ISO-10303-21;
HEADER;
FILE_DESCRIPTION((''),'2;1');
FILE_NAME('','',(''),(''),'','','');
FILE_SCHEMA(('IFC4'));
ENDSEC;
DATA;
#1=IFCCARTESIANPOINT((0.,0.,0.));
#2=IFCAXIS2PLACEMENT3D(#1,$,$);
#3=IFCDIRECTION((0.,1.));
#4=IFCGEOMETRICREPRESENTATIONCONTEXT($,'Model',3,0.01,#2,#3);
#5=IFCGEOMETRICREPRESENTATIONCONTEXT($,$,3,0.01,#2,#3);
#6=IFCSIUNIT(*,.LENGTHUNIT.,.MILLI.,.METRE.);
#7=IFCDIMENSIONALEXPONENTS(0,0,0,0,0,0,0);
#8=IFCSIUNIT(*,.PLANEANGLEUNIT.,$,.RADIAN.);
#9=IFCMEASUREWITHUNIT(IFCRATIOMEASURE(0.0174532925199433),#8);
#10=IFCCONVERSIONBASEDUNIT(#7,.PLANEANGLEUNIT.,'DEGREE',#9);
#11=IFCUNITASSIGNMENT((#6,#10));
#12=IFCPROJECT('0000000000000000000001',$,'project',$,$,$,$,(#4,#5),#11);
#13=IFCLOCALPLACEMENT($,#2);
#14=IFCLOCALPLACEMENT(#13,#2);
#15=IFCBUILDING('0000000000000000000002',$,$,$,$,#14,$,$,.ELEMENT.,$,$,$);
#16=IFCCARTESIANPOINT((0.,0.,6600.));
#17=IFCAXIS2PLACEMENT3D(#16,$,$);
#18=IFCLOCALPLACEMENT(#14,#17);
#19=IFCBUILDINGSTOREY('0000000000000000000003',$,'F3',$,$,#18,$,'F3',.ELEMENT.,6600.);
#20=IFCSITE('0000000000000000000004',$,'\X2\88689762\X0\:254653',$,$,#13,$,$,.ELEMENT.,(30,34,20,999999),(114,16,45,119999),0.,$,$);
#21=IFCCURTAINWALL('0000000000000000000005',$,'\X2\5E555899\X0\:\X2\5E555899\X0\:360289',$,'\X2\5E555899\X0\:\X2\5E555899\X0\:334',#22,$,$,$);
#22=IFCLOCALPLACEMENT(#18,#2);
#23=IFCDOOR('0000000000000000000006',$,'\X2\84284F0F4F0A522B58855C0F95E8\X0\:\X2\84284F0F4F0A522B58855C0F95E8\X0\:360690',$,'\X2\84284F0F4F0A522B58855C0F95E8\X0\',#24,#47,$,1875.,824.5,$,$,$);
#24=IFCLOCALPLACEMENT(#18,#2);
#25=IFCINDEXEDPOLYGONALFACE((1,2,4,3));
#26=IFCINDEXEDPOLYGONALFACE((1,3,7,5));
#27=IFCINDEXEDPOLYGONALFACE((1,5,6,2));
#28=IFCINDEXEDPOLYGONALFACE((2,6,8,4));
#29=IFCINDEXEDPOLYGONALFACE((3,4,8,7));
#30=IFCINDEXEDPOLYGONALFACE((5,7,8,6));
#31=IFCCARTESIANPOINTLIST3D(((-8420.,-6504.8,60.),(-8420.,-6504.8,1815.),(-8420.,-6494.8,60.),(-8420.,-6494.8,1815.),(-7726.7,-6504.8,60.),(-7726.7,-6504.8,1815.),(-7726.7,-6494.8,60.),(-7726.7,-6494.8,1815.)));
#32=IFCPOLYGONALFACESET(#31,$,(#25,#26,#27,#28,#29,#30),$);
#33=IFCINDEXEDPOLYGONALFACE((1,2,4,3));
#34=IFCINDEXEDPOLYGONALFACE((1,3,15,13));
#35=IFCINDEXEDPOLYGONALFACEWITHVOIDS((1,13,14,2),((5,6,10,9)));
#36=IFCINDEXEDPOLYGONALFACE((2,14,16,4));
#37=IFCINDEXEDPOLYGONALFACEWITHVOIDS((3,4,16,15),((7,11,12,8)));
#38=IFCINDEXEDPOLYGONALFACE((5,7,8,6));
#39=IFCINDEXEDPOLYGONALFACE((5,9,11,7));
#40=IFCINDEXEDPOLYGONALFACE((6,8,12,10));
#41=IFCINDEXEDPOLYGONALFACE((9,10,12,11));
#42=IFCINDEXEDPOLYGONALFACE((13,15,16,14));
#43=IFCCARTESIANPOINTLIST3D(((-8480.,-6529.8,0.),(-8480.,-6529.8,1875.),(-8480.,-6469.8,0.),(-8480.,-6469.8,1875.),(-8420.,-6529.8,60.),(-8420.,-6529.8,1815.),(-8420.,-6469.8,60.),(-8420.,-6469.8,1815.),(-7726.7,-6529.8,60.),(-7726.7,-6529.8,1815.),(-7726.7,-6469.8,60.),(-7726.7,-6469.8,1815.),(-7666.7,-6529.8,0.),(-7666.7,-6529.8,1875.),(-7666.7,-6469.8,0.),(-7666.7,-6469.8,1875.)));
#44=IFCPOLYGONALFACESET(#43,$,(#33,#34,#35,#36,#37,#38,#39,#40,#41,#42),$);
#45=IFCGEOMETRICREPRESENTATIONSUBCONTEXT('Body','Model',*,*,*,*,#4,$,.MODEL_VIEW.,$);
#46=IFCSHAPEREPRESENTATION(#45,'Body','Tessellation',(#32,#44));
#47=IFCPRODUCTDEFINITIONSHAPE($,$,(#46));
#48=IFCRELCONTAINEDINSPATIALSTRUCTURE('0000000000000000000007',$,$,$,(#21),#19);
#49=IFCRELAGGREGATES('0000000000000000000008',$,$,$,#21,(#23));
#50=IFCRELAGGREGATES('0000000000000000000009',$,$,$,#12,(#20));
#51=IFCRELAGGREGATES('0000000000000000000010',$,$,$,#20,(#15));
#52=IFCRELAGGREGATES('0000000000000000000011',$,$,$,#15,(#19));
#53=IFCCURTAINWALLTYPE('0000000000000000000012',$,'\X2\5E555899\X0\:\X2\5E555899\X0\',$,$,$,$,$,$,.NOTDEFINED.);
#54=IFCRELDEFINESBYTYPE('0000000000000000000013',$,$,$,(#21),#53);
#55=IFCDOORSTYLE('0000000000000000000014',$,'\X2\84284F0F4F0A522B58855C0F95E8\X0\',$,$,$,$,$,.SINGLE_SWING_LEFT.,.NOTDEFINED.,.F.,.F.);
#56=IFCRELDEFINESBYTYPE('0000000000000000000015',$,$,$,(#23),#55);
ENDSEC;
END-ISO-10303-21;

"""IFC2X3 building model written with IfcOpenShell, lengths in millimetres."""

from ifc_helpers import new_model, entity, si_unit, converted_unit, direction, frame, origin, origin_2d_with_axis, place, context, subcontext, project, spatial, polyline, rectangle, outline, extrude, source, transform, mapped, type_object, type_shapes, element, aggregate, save


model = new_model("IFC2X3")

# Units and contexts
model_context = context("Model", 3, precision=0.01, world=origin(), true_north=direction((0.0, 1.0)))
context_of_model = context(None, 3, precision=0.01, world=origin(), true_north=direction((0.0, 1.0)))
body_context = subcontext(model_context, "Body", "Model", "MODEL_VIEW")
ifc_project = project(units=[si_unit("LENGTHUNIT", "METRE", prefix="MILLI"), converted_unit("PLANEANGLEUNIT", "DEGREE", entity("IfcRatioMeasure", 0.0174532925199433), si_unit("PLANEANGLEUNIT", "RADIAN"), dimensions=[0, 0, 0, 0, 0, 0, 0])], contexts=[model_context, context_of_model])

# Site, building, storey
site_placement = place(None, origin())
site = spatial("IfcSite", under=ifc_project, at=site_placement, Name="表面:254653", CompositionType="ELEMENT", RefLatitude=(30, 34, 20, 999999), RefLongitude=(114, 16, 45, 119999), RefElevation=0.0)
building_placement = place(site_placement, origin())
building = spatial("IfcBuilding", under=site, at=building_placement, CompositionType="ELEMENT")
storey_placement = place(building_placement, frame((0.0, 0.0, 6600.0)))
storey = spatial("IfcBuildingStorey", under=building, at=storey_placement, Name="F3", LongName="F3", CompositionType="ELEMENT", Elevation=6600.0)

# Curtain wall
curtain_wall_type_1 = type_object("IfcCurtainWallType", Name="幕墙:幕墙", PredefinedType="NOTDEFINED")
curtain_wall_placement = place(storey_placement, frame((0.0, 0.0, -6600.0)))
curtain_wall = element("IfcCurtainWall", 1, at=curtain_wall_placement, inside=storey, type_object=curtain_wall_type_1, Name="幕墙:幕墙:360289", ObjectType="幕墙:幕墙:334")

# Door
door_style = type_object("IfcDoorStyle", Name="萨伏伊别墅小门", ConstructionType="NOTDEFINED", OperationType="SINGLE_SWING_LEFT", ParameterTakesPrecedence=False, Sizeable=False)
shared_shape_1 = source(origin(), body_context, "Body", "SweptSolid", [
    extrude(rectangle(XDim=10.0, YDim=693.3, at=origin_2d_with_axis()), frame((0.0, 0.0, 60.0), z_axis=(0.0, 0.0, 1.0), x_axis=(0.0, 1.0, 0.0)), (0.0, 0.0, 1.0), 1755.0),
    extrude(outline(polyline([(-406.7, -937.5), (406.7, -937.5), (406.7, 937.5), (-406.7, 937.5), (-406.7, -937.5)]), holes=[polyline([(346.7, -877.5), (-346.7, -877.5), (-346.7, 877.5), (346.7, 877.5), (346.7, -877.5)])]), frame((0.0, -30.0, 937.5), z_axis=(0.0, 1.0, 0.0), x_axis=(1.0, 0.0, 0.0)), (0.0, 0.0, 1.0), 60.0),
])
type_shapes(door_style, [shared_shape_1])
door_placement = place(curtain_wall_placement, frame((-8073.3, -6499.8, 6600.0)))
door = element("IfcDoor", 2, at=door_placement, type_object=door_style, Name="萨伏伊别墅小门:萨伏伊别墅小门:360690", ObjectType="萨伏伊别墅小门", OverallHeight=1875.0, OverallWidth=824.5, context=body_context, shape_type="MappedRepresentation", body=[
    mapped(shared_shape_1, transform((0.0, 0.0, 0.0), scale=1.0)),
])
aggregate(curtain_wall, [door])

save(model, "model.ifc")
